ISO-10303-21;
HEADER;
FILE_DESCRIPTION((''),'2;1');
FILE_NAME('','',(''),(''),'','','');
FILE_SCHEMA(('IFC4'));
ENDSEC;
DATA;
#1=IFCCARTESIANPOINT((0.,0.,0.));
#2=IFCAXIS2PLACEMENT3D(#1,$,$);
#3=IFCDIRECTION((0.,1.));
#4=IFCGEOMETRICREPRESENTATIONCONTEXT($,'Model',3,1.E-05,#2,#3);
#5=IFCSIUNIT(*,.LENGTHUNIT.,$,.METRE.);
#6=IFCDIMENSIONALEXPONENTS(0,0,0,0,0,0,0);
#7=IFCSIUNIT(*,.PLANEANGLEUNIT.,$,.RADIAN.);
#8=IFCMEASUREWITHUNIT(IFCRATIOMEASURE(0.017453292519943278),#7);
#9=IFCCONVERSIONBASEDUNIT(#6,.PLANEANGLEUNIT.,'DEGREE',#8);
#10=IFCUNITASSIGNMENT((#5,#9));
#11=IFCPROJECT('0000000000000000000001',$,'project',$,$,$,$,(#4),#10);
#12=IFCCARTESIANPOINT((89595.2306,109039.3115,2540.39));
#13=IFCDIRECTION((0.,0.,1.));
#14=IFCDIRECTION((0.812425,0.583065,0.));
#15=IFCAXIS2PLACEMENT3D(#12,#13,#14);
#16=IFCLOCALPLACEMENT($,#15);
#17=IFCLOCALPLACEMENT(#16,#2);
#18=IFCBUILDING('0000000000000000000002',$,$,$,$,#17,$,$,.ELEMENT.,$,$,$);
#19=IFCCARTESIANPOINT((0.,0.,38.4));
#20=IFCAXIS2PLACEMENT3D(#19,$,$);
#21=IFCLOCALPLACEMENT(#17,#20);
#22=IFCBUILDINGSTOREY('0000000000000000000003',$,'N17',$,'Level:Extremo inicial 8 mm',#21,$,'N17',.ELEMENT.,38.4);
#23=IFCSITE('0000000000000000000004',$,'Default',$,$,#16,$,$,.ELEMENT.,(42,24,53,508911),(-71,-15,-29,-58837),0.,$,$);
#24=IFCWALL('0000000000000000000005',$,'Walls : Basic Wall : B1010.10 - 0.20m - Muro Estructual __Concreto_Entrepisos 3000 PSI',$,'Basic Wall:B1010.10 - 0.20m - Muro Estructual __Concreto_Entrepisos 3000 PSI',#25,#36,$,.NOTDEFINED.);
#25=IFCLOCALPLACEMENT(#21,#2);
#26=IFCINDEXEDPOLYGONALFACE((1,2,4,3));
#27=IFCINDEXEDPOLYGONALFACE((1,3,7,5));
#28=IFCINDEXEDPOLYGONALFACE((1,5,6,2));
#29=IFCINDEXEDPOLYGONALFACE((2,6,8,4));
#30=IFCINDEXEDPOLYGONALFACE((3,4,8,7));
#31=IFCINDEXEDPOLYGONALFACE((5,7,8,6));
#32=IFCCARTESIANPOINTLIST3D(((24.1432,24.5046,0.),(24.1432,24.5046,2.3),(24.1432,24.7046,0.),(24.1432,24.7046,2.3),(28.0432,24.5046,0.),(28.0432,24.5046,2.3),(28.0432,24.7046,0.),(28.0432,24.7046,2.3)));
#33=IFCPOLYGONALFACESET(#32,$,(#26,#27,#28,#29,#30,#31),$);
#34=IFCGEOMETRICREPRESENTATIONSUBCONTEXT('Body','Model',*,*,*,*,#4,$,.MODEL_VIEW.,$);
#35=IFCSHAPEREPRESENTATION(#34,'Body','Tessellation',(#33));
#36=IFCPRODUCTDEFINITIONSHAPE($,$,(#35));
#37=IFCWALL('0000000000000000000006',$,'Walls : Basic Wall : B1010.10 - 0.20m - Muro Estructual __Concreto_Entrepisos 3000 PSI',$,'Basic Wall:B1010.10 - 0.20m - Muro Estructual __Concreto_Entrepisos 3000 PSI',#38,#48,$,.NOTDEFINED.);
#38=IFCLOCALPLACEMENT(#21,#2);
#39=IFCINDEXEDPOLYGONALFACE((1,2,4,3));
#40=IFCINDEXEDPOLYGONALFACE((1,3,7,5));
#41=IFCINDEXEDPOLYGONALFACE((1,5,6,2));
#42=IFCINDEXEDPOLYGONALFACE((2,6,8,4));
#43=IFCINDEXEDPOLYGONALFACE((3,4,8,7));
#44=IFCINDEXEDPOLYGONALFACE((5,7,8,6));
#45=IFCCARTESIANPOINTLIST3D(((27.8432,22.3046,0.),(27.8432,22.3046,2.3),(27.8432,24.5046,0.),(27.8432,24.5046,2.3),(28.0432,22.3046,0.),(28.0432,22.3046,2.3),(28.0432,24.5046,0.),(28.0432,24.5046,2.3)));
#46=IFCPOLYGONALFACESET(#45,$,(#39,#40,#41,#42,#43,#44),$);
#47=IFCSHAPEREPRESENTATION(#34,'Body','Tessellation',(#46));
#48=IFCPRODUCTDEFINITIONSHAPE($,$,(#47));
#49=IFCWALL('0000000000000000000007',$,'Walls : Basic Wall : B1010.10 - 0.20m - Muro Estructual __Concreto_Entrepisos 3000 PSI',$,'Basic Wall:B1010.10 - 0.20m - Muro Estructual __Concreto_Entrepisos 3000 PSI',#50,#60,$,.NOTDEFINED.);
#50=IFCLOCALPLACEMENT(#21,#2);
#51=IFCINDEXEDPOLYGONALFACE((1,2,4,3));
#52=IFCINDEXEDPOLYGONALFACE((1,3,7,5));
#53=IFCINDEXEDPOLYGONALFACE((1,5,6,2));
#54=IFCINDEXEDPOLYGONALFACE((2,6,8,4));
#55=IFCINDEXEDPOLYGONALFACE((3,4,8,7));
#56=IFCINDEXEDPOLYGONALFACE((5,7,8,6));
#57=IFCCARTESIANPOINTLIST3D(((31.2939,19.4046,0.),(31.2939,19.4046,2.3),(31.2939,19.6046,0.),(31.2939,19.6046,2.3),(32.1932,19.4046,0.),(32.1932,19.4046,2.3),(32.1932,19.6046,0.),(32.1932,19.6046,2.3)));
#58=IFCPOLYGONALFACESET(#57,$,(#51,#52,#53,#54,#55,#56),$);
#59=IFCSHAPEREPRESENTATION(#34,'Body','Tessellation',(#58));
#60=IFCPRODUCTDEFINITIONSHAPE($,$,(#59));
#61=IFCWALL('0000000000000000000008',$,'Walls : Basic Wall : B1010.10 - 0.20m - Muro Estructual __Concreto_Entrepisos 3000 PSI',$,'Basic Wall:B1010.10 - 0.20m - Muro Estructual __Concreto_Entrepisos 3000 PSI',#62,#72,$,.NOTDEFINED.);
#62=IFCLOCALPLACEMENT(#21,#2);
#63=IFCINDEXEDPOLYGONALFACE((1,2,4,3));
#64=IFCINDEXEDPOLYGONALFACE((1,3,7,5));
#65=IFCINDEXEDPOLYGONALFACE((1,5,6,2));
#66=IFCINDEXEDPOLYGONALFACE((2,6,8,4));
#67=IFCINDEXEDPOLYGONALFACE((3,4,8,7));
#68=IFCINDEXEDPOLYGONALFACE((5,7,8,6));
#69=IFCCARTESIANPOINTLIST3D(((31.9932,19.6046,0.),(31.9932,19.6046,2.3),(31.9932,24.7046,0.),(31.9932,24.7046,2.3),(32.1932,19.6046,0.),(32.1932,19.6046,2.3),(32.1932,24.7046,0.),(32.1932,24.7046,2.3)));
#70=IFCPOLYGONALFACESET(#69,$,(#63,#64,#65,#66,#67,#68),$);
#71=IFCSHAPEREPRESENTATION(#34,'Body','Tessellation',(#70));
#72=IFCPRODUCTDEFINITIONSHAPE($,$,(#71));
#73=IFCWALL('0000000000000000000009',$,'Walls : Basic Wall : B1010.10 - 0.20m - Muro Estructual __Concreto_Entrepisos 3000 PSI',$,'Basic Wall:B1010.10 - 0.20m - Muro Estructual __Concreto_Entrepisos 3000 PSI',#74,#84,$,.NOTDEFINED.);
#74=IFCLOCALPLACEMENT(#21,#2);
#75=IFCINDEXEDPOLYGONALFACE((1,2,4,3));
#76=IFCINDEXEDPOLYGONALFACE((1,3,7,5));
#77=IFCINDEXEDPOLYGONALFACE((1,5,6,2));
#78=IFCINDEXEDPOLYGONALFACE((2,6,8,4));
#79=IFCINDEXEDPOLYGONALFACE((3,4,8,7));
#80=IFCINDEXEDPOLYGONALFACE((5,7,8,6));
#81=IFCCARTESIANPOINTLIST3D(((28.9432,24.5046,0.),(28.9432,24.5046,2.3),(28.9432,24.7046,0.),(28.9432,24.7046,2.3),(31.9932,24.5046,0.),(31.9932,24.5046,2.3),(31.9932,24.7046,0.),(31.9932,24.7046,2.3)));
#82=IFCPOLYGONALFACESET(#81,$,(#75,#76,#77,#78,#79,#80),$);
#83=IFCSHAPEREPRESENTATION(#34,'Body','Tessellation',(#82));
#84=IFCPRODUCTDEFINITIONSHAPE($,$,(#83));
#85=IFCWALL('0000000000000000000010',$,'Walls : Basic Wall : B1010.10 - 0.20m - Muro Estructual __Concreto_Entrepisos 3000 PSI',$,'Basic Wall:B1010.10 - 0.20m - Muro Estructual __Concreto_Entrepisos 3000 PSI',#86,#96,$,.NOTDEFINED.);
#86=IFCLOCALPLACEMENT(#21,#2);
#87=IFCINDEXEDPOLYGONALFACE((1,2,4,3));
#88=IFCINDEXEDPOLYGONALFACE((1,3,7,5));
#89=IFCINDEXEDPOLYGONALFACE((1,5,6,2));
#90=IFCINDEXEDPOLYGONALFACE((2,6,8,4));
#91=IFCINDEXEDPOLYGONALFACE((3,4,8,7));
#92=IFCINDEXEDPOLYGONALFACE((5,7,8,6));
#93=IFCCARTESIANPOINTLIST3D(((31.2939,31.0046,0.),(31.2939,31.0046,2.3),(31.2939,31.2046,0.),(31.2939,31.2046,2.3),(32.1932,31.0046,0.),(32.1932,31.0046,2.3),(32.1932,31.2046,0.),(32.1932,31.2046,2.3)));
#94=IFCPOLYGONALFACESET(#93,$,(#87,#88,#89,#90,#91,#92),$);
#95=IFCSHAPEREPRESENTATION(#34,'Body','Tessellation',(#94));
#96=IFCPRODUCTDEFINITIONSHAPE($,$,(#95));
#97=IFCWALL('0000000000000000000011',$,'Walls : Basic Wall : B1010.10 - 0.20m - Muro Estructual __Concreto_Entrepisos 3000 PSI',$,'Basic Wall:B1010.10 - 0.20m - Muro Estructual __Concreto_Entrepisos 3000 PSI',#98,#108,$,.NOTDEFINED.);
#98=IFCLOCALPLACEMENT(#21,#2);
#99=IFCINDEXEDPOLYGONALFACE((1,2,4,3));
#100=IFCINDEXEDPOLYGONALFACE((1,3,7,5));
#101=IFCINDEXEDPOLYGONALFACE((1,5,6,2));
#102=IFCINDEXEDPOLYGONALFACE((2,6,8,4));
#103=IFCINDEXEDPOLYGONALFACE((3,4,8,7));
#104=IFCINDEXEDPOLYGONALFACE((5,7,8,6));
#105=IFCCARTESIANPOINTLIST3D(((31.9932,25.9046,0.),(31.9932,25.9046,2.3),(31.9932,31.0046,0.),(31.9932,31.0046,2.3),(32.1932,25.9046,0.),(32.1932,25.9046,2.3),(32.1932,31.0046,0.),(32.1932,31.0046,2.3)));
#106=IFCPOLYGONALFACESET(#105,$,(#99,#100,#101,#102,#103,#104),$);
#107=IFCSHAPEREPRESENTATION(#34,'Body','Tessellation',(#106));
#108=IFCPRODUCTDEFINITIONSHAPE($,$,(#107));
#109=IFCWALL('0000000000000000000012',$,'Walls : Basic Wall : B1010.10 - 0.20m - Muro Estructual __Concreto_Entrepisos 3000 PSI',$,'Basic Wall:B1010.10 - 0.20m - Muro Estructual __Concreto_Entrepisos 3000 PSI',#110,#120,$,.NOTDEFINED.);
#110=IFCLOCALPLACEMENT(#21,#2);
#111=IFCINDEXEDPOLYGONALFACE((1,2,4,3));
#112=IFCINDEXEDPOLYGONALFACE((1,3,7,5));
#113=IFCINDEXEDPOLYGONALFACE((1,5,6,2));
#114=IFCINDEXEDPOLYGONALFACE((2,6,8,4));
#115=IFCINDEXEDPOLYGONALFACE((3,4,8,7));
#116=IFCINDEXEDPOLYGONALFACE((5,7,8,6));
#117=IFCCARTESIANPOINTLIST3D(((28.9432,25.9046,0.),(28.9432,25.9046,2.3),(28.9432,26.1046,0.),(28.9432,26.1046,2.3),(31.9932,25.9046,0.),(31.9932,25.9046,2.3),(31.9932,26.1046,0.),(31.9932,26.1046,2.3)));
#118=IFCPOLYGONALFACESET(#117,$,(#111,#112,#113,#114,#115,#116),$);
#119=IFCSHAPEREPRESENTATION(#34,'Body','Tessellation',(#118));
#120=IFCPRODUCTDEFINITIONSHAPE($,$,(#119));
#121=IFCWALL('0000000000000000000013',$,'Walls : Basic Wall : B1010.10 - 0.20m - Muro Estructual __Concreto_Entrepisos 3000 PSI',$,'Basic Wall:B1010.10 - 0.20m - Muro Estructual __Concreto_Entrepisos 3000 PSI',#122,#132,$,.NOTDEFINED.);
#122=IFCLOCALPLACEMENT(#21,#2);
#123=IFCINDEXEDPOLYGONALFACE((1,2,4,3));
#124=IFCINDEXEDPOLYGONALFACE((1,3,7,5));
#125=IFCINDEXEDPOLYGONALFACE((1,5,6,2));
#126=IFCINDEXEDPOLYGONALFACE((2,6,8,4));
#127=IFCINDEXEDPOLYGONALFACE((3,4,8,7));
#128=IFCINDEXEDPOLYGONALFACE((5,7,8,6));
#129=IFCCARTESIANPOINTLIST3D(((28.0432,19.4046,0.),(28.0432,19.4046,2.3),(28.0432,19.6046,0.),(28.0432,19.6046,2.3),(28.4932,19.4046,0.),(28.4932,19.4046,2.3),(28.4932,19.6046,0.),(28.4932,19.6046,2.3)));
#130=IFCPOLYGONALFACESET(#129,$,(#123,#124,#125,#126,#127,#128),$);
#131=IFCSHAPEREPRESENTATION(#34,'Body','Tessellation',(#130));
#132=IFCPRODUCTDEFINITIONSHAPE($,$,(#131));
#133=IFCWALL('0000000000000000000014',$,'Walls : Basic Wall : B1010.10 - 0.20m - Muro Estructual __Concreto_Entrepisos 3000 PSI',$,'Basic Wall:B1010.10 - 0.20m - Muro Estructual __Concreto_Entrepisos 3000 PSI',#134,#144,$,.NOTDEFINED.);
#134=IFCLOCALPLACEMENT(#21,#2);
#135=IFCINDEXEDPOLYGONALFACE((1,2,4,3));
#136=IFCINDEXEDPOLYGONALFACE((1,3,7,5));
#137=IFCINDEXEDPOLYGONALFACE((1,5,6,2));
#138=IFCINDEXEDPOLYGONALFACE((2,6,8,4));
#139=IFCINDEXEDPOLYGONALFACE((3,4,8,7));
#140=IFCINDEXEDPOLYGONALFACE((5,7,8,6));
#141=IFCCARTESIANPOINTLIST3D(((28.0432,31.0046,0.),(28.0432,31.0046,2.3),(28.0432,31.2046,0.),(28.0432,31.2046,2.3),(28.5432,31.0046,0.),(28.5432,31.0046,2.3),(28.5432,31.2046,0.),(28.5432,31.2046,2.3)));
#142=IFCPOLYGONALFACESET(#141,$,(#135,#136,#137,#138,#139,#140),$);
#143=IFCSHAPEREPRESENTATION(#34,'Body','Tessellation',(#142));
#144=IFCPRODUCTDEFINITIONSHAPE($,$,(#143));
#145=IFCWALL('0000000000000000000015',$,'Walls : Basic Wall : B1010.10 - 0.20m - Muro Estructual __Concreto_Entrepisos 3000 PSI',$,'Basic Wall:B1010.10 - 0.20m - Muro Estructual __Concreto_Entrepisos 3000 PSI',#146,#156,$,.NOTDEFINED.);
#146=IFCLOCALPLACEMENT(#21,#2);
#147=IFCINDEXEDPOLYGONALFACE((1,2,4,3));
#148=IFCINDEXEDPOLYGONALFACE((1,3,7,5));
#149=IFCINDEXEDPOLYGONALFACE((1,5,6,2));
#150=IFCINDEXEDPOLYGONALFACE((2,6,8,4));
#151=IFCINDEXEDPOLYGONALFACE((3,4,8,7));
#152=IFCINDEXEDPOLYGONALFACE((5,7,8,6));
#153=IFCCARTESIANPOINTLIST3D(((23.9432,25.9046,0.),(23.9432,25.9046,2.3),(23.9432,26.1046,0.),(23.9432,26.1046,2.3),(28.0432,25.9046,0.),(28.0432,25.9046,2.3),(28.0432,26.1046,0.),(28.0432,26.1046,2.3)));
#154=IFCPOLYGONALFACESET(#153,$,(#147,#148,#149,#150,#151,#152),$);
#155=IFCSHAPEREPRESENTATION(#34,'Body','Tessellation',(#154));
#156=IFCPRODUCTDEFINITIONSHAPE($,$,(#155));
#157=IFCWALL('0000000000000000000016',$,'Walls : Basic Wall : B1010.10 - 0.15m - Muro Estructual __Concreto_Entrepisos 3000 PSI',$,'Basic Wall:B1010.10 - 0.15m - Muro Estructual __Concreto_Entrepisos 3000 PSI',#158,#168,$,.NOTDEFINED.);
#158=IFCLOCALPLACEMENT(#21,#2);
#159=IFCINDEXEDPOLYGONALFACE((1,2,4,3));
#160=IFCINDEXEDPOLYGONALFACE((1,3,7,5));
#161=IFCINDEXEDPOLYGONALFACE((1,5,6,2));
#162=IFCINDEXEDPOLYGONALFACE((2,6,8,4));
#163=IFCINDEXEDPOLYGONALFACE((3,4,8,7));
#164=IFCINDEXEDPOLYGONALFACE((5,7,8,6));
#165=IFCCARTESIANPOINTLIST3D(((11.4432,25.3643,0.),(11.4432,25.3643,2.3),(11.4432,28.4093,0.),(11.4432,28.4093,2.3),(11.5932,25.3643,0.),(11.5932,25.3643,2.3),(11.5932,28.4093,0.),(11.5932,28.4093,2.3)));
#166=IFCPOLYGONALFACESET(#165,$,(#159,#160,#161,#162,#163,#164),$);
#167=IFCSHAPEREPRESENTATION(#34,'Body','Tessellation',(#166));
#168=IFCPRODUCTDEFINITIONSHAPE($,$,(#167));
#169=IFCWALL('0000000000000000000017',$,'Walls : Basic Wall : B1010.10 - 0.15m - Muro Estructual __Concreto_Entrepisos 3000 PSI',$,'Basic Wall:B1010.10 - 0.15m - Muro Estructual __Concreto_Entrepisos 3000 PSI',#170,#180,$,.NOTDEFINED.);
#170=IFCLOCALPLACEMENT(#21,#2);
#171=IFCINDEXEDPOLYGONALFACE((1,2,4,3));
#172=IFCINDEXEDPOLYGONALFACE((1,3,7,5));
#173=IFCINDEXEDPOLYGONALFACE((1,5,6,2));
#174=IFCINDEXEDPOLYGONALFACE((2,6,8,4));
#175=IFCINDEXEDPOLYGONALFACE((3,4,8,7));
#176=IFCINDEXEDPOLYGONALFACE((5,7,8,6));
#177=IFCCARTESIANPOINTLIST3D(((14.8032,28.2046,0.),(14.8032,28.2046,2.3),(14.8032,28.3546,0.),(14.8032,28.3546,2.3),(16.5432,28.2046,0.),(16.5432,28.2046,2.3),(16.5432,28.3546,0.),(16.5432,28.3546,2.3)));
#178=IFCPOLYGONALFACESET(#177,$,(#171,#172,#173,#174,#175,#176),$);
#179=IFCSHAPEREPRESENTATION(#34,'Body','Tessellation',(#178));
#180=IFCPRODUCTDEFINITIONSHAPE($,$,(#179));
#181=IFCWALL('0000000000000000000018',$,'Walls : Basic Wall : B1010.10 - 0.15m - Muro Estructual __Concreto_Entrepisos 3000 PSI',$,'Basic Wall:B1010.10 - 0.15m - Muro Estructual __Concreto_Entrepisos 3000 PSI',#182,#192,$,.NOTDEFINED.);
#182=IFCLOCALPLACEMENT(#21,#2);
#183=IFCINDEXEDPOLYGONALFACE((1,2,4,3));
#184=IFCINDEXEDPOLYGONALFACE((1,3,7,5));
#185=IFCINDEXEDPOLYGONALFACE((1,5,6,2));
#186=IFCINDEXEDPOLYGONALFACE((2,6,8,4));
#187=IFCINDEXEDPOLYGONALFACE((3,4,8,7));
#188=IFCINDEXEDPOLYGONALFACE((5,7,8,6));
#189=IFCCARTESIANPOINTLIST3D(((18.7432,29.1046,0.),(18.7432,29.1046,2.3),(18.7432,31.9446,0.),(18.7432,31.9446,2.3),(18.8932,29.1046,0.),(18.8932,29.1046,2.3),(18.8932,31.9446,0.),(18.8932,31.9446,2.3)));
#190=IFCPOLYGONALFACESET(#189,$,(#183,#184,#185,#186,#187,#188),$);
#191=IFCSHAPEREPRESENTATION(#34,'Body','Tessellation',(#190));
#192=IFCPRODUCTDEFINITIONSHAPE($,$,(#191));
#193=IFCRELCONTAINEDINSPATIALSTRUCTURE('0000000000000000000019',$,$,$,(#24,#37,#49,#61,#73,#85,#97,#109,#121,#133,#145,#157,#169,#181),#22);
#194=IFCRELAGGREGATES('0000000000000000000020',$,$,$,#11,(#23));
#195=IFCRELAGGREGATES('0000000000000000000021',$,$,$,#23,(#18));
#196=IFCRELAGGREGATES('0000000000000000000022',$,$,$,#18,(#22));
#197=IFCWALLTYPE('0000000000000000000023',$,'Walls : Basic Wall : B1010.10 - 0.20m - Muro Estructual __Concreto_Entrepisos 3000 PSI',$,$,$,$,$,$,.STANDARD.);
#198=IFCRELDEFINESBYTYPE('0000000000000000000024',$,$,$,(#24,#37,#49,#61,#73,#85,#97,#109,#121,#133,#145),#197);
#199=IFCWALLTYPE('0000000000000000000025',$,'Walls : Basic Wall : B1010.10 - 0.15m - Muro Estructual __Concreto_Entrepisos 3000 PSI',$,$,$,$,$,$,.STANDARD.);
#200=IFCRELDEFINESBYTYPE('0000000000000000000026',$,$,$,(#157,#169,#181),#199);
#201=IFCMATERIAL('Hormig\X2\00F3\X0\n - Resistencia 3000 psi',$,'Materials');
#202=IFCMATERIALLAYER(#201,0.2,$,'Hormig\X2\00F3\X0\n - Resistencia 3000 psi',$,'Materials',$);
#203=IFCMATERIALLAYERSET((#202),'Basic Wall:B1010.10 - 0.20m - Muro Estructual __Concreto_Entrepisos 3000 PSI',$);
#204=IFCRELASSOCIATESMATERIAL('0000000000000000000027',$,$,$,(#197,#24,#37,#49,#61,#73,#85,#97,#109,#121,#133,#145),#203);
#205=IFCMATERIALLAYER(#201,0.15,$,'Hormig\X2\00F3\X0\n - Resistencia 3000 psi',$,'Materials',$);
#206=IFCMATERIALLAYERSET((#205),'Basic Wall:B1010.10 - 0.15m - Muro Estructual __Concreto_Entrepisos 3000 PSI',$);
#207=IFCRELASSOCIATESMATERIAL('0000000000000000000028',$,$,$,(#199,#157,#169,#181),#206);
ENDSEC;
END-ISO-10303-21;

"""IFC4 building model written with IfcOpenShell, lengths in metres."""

from ifc_helpers import new_model, entity, si_unit, converted_unit, direction, frame, frame_2d, origin, place, context, subcontext, project, spatial, rectangle, extrude, material, layer, layer_set, layer_usage, type_object, element, save


model = new_model("IFC4")

# Units and contexts
model_context = context("Model", 3, precision=1e-05, world=origin(), true_north=direction((0.0, 1.0)))
body_context = subcontext(model_context, "Body", "Model", "MODEL_VIEW")
ifc_project = project(units=[si_unit("LENGTHUNIT", "METRE"), converted_unit("PLANEANGLEUNIT", "DEGREE", entity("IfcRatioMeasure", 0.017453292519943278), si_unit("PLANEANGLEUNIT", "RADIAN"), dimensions=[0, 0, 0, 0, 0, 0, 0])], contexts=[model_context])

# Site, building, storey
site_placement = place(None, frame((89595.2306, 109039.3115, 2540.39), z_axis=(0.0, 0.0, 1.0), x_axis=(0.812425, 0.583065, 0.0)))
site = spatial("IfcSite", under=ifc_project, at=site_placement, Name="Default", CompositionType="ELEMENT", RefLatitude=(42, 24, 53, 508911), RefLongitude=(-71, -15, -29, -58837), RefElevation=0.0)
building_placement = place(site_placement, origin())
building = spatial("IfcBuilding", under=site, at=building_placement, CompositionType="ELEMENT")
storey_placement = place(building_placement, frame((0.0, 0.0, 38.4)))
storey = spatial("IfcBuildingStorey", under=building, at=storey_placement, Name="N17", ObjectType="Level:Extremo inicial 8 mm", LongName="N17", CompositionType="ELEMENT", Elevation=38.4)

# Walls
ifc_material_1 = material(Name="Hormigón - Resistencia 3000 psi", Category="Materials")
ifc_layer_1 = layer(ifc_material_1, 0.2, Name="Hormigón - Resistencia 3000 psi", Category="Materials")
ifc_layer_set_1 = layer_set([ifc_layer_1], Name="Basic Wall:B1010.10 - 0.20m - Muro Estructual __Concreto_Entrepisos 3000 PSI")
wall_type_1 = type_object("IfcWallType", Name="Walls : Basic Wall : B1010.10 - 0.20m - Muro Estructual __Concreto_Entrepisos 3000 PSI", PredefinedType="STANDARD", material=ifc_layer_set_1)
ifc_layer_usage_1 = layer_usage(ifc_layer_set_1, "AXIS2", "NEGATIVE", 0.1)
wall_1_placement = place(storey_placement, frame((24.1432, 24.6046, 0.0)))
element("IfcWall", 1, at=wall_1_placement, inside=storey, type_object=wall_type_1, material=ifc_layer_usage_1, Name="Walls : Basic Wall : B1010.10 - 0.20m - Muro Estructual __Concreto_Entrepisos 3000 PSI", ObjectType="Basic Wall:B1010.10 - 0.20m - Muro Estructual __Concreto_Entrepisos 3000 PSI", PredefinedType="NOTDEFINED", context=body_context, shape_type="SweptSolid", body=[
    extrude(rectangle(XDim=3.9, YDim=0.2, at=frame_2d((1.95, 0.0), x_axis=(-1.0, 0.0))), origin(), (0.0, 0.0, 1.0), 2.3),
])
ifc_layer_usage_2 = layer_usage(ifc_layer_set_1, "AXIS2", "NEGATIVE", 0.1)
wall_2_placement = place(storey_placement, frame((27.9432, 24.5046, 0.0), z_axis=(0.0, 0.0, 1.0), x_axis=(0.0, -1.0, 0.0)))
element("IfcWall", 2, at=wall_2_placement, inside=storey, type_object=wall_type_1, material=ifc_layer_usage_2, Name="Walls : Basic Wall : B1010.10 - 0.20m - Muro Estructual __Concreto_Entrepisos 3000 PSI", ObjectType="Basic Wall:B1010.10 - 0.20m - Muro Estructual __Concreto_Entrepisos 3000 PSI", PredefinedType="NOTDEFINED", context=body_context, shape_type="SweptSolid", body=[
    extrude(rectangle(XDim=2.2, YDim=0.2, at=frame_2d((1.1, 0.0), x_axis=(-1.0, 0.0))), origin(), (0.0, 0.0, 1.0), 2.3),
])
ifc_layer_usage_3 = layer_usage(ifc_layer_set_1, "AXIS2", "NEGATIVE", 0.1)
wall_3_placement = place(storey_placement, frame((31.2939, 19.5046, 0.0)))
element("IfcWall", 3, at=wall_3_placement, inside=storey, type_object=wall_type_1, material=ifc_layer_usage_3, Name="Walls : Basic Wall : B1010.10 - 0.20m - Muro Estructual __Concreto_Entrepisos 3000 PSI", ObjectType="Basic Wall:B1010.10 - 0.20m - Muro Estructual __Concreto_Entrepisos 3000 PSI", PredefinedType="NOTDEFINED", context=body_context, shape_type="SweptSolid", body=[
    extrude(rectangle(XDim=0.8993, YDim=0.2, at=frame_2d((0.4497, 0.0), x_axis=(-1.0, 0.0))), origin(), (0.0, 0.0, 1.0), 2.3),
])
ifc_layer_usage_4 = layer_usage(ifc_layer_set_1, "AXIS2", "NEGATIVE", 0.1)
wall_4_placement = place(storey_placement, frame((32.0932, 19.6046, 0.0), z_axis=(0.0, 0.0, 1.0), x_axis=(0.0, 1.0, 0.0)))
element("IfcWall", 4, at=wall_4_placement, inside=storey, type_object=wall_type_1, material=ifc_layer_usage_4, Name="Walls : Basic Wall : B1010.10 - 0.20m - Muro Estructual __Concreto_Entrepisos 3000 PSI", ObjectType="Basic Wall:B1010.10 - 0.20m - Muro Estructual __Concreto_Entrepisos 3000 PSI", PredefinedType="NOTDEFINED", context=body_context, shape_type="SweptSolid", body=[
    extrude(rectangle(XDim=5.1, YDim=0.2, at=frame_2d((2.55, 0.0), x_axis=(-1.0, 0.0))), origin(), (0.0, 0.0, 1.0), 2.3),
])
ifc_layer_usage_5 = layer_usage(ifc_layer_set_1, "AXIS2", "NEGATIVE", 0.1)
wall_5_placement = place(storey_placement, frame((31.9932, 24.6046, 0.0), z_axis=(0.0, 0.0, 1.0), x_axis=(-1.0, 0.0, 0.0)))
element("IfcWall", 5, at=wall_5_placement, inside=storey, type_object=wall_type_1, material=ifc_layer_usage_5, Name="Walls : Basic Wall : B1010.10 - 0.20m - Muro Estructual __Concreto_Entrepisos 3000 PSI", ObjectType="Basic Wall:B1010.10 - 0.20m - Muro Estructual __Concreto_Entrepisos 3000 PSI", PredefinedType="NOTDEFINED", context=body_context, shape_type="SweptSolid", body=[
    extrude(rectangle(XDim=3.05, YDim=0.2, at=frame_2d((1.525, 0.0), x_axis=(-1.0, 0.0))), origin(), (0.0, 0.0, 1.0), 2.3),
])
ifc_layer_usage_6 = layer_usage(ifc_layer_set_1, "AXIS2", "POSITIVE", -0.1)
wall_6_placement = place(storey_placement, frame((31.2939, 31.1046, 0.0)))
element("IfcWall", 6, at=wall_6_placement, inside=storey, type_object=wall_type_1, material=ifc_layer_usage_6, Name="Walls : Basic Wall : B1010.10 - 0.20m - Muro Estructual __Concreto_Entrepisos 3000 PSI", ObjectType="Basic Wall:B1010.10 - 0.20m - Muro Estructual __Concreto_Entrepisos 3000 PSI", PredefinedType="NOTDEFINED", context=body_context, shape_type="SweptSolid", body=[
    extrude(rectangle(XDim=0.8993, YDim=0.2, at=frame_2d((0.4497, 0.0), x_axis=(-1.0, 0.0))), origin(), (0.0, 0.0, 1.0), 2.3),
])
ifc_layer_usage_7 = layer_usage(ifc_layer_set_1, "AXIS2", "POSITIVE", -0.1)
wall_7_placement = place(storey_placement, frame((32.0932, 31.0046, 0.0), z_axis=(0.0, 0.0, 1.0), x_axis=(0.0, -1.0, 0.0)))
element("IfcWall", 7, at=wall_7_placement, inside=storey, type_object=wall_type_1, material=ifc_layer_usage_7, Name="Walls : Basic Wall : B1010.10 - 0.20m - Muro Estructual __Concreto_Entrepisos 3000 PSI", ObjectType="Basic Wall:B1010.10 - 0.20m - Muro Estructual __Concreto_Entrepisos 3000 PSI", PredefinedType="NOTDEFINED", context=body_context, shape_type="SweptSolid", body=[
    extrude(rectangle(XDim=5.1, YDim=0.2, at=frame_2d((2.55, 0.0), x_axis=(-1.0, 0.0))), origin(), (0.0, 0.0, 1.0), 2.3),
])
ifc_layer_usage_8 = layer_usage(ifc_layer_set_1, "AXIS2", "POSITIVE", -0.1)
wall_8_placement = place(storey_placement, frame((31.9932, 26.0046, 0.0), z_axis=(0.0, 0.0, 1.0), x_axis=(-1.0, 0.0, 0.0)))
element("IfcWall", 8, at=wall_8_placement, inside=storey, type_object=wall_type_1, material=ifc_layer_usage_8, Name="Walls : Basic Wall : B1010.10 - 0.20m - Muro Estructual __Concreto_Entrepisos 3000 PSI", ObjectType="Basic Wall:B1010.10 - 0.20m - Muro Estructual __Concreto_Entrepisos 3000 PSI", PredefinedType="NOTDEFINED", context=body_context, shape_type="SweptSolid", body=[
    extrude(rectangle(XDim=3.05, YDim=0.2, at=frame_2d((1.525, 0.0), x_axis=(-1.0, 0.0))), origin(), (0.0, 0.0, 1.0), 2.3),
])
ifc_layer_usage_9 = layer_usage(ifc_layer_set_1, "AXIS2", "NEGATIVE", 0.1)
wall_9_placement = place(storey_placement, frame((28.4932, 19.5046, 0.0), z_axis=(0.0, 0.0, 1.0), x_axis=(-1.0, 0.0, 0.0)))
element("IfcWall", 9, at=wall_9_placement, inside=storey, type_object=wall_type_1, material=ifc_layer_usage_9, Name="Walls : Basic Wall : B1010.10 - 0.20m - Muro Estructual __Concreto_Entrepisos 3000 PSI", ObjectType="Basic Wall:B1010.10 - 0.20m - Muro Estructual __Concreto_Entrepisos 3000 PSI", PredefinedType="NOTDEFINED", context=body_context, shape_type="SweptSolid", body=[
    extrude(rectangle(XDim=0.45, YDim=0.2, at=frame_2d((0.225, 0.0), x_axis=(-1.0, 0.0))), origin(), (0.0, 0.0, 1.0), 2.3),
])
ifc_layer_usage_10 = layer_usage(ifc_layer_set_1, "AXIS2", "NEGATIVE", 0.1)
wall_10_placement = place(storey_placement, frame((28.5432, 31.1046, 0.0), z_axis=(0.0, 0.0, 1.0), x_axis=(-1.0, 0.0, 0.0)))
element("IfcWall", 10, at=wall_10_placement, inside=storey, type_object=wall_type_1, material=ifc_layer_usage_10, Name="Walls : Basic Wall : B1010.10 - 0.20m - Muro Estructual __Concreto_Entrepisos 3000 PSI", ObjectType="Basic Wall:B1010.10 - 0.20m - Muro Estructual __Concreto_Entrepisos 3000 PSI", PredefinedType="NOTDEFINED", context=body_context, shape_type="SweptSolid", body=[
    extrude(rectangle(XDim=0.5, YDim=0.2, at=frame_2d((0.25, 0.0), x_axis=(-1.0, 0.0))), origin(), (0.0, 0.0, 1.0), 2.3),
])
ifc_layer_usage_11 = layer_usage(ifc_layer_set_1, "AXIS2", "NEGATIVE", 0.1)
wall_11_placement = place(storey_placement, frame((23.9432, 26.0046, 0.0)))
element("IfcWall", 11, at=wall_11_placement, inside=storey, type_object=wall_type_1, material=ifc_layer_usage_11, Name="Walls : Basic Wall : B1010.10 - 0.20m - Muro Estructual __Concreto_Entrepisos 3000 PSI", ObjectType="Basic Wall:B1010.10 - 0.20m - Muro Estructual __Concreto_Entrepisos 3000 PSI", PredefinedType="NOTDEFINED", context=body_context, shape_type="SweptSolid", body=[
    extrude(rectangle(XDim=4.1, YDim=0.2, at=frame_2d((2.05, 0.0), x_axis=(-1.0, 0.0))), origin(), (0.0, 0.0, 1.0), 2.3),
])
ifc_layer_2 = layer(ifc_material_1, 0.15, Name="Hormigón - Resistencia 3000 psi", Category="Materials")
ifc_layer_set_2 = layer_set([ifc_layer_2], Name="Basic Wall:B1010.10 - 0.15m - Muro Estructual __Concreto_Entrepisos 3000 PSI")
ifc_layer_usage_12 = layer_usage(ifc_layer_set_2, "AXIS2", "NEGATIVE", 0.075)
wall_type_2 = type_object("IfcWallType", Name="Walls : Basic Wall : B1010.10 - 0.15m - Muro Estructual __Concreto_Entrepisos 3000 PSI", PredefinedType="STANDARD", material=ifc_layer_set_2)
wall_12_placement = place(storey_placement, frame((11.5182, 25.3643, 0.0), z_axis=(0.0, 0.0, 1.0), x_axis=(0.0, 1.0, 0.0)))
element("IfcWall", 12, at=wall_12_placement, inside=storey, type_object=wall_type_2, material=ifc_layer_usage_12, Name="Walls : Basic Wall : B1010.10 - 0.15m - Muro Estructual __Concreto_Entrepisos 3000 PSI", ObjectType="Basic Wall:B1010.10 - 0.15m - Muro Estructual __Concreto_Entrepisos 3000 PSI", PredefinedType="NOTDEFINED", context=body_context, shape_type="SweptSolid", body=[
    extrude(rectangle(XDim=3.045, YDim=0.15, at=frame_2d((1.5225, 0.0), x_axis=(-1.0, 0.0))), origin(), (0.0, 0.0, 1.0), 2.3),
])
ifc_layer_usage_13 = layer_usage(ifc_layer_set_2, "AXIS2", "NEGATIVE", 0.075)
wall_13_placement = place(storey_placement, frame((16.5432, 28.2796, 0.0), z_axis=(0.0, 0.0, 1.0), x_axis=(-1.0, 0.0, 0.0)))
element("IfcWall", 13, at=wall_13_placement, inside=storey, type_object=wall_type_2, material=ifc_layer_usage_13, Name="Walls : Basic Wall : B1010.10 - 0.15m - Muro Estructual __Concreto_Entrepisos 3000 PSI", ObjectType="Basic Wall:B1010.10 - 0.15m - Muro Estructual __Concreto_Entrepisos 3000 PSI", PredefinedType="NOTDEFINED", context=body_context, shape_type="SweptSolid", body=[
    extrude(rectangle(XDim=1.74, YDim=0.15, at=frame_2d((0.87, 0.0), x_axis=(-1.0, 0.0))), origin(), (0.0, 0.0, 1.0), 2.3),
])
ifc_layer_usage_14 = layer_usage(ifc_layer_set_2, "AXIS2", "NEGATIVE", 0.075)
wall_14_placement = place(storey_placement, frame((18.8182, 31.9446, 0.0), z_axis=(0.0, 0.0, 1.0), x_axis=(0.0, -1.0, 0.0)))
element("IfcWall", 14, at=wall_14_placement, inside=storey, type_object=wall_type_2, material=ifc_layer_usage_14, Name="Walls : Basic Wall : B1010.10 - 0.15m - Muro Estructual __Concreto_Entrepisos 3000 PSI", ObjectType="Basic Wall:B1010.10 - 0.15m - Muro Estructual __Concreto_Entrepisos 3000 PSI", PredefinedType="NOTDEFINED", context=body_context, shape_type="SweptSolid", body=[
    extrude(rectangle(XDim=2.84, YDim=0.15, at=frame_2d((1.42, 0.0), x_axis=(-1.0, 0.0))), origin(), (0.0, 0.0, 1.0), 2.3),
])

save(model, "model.ifc")
